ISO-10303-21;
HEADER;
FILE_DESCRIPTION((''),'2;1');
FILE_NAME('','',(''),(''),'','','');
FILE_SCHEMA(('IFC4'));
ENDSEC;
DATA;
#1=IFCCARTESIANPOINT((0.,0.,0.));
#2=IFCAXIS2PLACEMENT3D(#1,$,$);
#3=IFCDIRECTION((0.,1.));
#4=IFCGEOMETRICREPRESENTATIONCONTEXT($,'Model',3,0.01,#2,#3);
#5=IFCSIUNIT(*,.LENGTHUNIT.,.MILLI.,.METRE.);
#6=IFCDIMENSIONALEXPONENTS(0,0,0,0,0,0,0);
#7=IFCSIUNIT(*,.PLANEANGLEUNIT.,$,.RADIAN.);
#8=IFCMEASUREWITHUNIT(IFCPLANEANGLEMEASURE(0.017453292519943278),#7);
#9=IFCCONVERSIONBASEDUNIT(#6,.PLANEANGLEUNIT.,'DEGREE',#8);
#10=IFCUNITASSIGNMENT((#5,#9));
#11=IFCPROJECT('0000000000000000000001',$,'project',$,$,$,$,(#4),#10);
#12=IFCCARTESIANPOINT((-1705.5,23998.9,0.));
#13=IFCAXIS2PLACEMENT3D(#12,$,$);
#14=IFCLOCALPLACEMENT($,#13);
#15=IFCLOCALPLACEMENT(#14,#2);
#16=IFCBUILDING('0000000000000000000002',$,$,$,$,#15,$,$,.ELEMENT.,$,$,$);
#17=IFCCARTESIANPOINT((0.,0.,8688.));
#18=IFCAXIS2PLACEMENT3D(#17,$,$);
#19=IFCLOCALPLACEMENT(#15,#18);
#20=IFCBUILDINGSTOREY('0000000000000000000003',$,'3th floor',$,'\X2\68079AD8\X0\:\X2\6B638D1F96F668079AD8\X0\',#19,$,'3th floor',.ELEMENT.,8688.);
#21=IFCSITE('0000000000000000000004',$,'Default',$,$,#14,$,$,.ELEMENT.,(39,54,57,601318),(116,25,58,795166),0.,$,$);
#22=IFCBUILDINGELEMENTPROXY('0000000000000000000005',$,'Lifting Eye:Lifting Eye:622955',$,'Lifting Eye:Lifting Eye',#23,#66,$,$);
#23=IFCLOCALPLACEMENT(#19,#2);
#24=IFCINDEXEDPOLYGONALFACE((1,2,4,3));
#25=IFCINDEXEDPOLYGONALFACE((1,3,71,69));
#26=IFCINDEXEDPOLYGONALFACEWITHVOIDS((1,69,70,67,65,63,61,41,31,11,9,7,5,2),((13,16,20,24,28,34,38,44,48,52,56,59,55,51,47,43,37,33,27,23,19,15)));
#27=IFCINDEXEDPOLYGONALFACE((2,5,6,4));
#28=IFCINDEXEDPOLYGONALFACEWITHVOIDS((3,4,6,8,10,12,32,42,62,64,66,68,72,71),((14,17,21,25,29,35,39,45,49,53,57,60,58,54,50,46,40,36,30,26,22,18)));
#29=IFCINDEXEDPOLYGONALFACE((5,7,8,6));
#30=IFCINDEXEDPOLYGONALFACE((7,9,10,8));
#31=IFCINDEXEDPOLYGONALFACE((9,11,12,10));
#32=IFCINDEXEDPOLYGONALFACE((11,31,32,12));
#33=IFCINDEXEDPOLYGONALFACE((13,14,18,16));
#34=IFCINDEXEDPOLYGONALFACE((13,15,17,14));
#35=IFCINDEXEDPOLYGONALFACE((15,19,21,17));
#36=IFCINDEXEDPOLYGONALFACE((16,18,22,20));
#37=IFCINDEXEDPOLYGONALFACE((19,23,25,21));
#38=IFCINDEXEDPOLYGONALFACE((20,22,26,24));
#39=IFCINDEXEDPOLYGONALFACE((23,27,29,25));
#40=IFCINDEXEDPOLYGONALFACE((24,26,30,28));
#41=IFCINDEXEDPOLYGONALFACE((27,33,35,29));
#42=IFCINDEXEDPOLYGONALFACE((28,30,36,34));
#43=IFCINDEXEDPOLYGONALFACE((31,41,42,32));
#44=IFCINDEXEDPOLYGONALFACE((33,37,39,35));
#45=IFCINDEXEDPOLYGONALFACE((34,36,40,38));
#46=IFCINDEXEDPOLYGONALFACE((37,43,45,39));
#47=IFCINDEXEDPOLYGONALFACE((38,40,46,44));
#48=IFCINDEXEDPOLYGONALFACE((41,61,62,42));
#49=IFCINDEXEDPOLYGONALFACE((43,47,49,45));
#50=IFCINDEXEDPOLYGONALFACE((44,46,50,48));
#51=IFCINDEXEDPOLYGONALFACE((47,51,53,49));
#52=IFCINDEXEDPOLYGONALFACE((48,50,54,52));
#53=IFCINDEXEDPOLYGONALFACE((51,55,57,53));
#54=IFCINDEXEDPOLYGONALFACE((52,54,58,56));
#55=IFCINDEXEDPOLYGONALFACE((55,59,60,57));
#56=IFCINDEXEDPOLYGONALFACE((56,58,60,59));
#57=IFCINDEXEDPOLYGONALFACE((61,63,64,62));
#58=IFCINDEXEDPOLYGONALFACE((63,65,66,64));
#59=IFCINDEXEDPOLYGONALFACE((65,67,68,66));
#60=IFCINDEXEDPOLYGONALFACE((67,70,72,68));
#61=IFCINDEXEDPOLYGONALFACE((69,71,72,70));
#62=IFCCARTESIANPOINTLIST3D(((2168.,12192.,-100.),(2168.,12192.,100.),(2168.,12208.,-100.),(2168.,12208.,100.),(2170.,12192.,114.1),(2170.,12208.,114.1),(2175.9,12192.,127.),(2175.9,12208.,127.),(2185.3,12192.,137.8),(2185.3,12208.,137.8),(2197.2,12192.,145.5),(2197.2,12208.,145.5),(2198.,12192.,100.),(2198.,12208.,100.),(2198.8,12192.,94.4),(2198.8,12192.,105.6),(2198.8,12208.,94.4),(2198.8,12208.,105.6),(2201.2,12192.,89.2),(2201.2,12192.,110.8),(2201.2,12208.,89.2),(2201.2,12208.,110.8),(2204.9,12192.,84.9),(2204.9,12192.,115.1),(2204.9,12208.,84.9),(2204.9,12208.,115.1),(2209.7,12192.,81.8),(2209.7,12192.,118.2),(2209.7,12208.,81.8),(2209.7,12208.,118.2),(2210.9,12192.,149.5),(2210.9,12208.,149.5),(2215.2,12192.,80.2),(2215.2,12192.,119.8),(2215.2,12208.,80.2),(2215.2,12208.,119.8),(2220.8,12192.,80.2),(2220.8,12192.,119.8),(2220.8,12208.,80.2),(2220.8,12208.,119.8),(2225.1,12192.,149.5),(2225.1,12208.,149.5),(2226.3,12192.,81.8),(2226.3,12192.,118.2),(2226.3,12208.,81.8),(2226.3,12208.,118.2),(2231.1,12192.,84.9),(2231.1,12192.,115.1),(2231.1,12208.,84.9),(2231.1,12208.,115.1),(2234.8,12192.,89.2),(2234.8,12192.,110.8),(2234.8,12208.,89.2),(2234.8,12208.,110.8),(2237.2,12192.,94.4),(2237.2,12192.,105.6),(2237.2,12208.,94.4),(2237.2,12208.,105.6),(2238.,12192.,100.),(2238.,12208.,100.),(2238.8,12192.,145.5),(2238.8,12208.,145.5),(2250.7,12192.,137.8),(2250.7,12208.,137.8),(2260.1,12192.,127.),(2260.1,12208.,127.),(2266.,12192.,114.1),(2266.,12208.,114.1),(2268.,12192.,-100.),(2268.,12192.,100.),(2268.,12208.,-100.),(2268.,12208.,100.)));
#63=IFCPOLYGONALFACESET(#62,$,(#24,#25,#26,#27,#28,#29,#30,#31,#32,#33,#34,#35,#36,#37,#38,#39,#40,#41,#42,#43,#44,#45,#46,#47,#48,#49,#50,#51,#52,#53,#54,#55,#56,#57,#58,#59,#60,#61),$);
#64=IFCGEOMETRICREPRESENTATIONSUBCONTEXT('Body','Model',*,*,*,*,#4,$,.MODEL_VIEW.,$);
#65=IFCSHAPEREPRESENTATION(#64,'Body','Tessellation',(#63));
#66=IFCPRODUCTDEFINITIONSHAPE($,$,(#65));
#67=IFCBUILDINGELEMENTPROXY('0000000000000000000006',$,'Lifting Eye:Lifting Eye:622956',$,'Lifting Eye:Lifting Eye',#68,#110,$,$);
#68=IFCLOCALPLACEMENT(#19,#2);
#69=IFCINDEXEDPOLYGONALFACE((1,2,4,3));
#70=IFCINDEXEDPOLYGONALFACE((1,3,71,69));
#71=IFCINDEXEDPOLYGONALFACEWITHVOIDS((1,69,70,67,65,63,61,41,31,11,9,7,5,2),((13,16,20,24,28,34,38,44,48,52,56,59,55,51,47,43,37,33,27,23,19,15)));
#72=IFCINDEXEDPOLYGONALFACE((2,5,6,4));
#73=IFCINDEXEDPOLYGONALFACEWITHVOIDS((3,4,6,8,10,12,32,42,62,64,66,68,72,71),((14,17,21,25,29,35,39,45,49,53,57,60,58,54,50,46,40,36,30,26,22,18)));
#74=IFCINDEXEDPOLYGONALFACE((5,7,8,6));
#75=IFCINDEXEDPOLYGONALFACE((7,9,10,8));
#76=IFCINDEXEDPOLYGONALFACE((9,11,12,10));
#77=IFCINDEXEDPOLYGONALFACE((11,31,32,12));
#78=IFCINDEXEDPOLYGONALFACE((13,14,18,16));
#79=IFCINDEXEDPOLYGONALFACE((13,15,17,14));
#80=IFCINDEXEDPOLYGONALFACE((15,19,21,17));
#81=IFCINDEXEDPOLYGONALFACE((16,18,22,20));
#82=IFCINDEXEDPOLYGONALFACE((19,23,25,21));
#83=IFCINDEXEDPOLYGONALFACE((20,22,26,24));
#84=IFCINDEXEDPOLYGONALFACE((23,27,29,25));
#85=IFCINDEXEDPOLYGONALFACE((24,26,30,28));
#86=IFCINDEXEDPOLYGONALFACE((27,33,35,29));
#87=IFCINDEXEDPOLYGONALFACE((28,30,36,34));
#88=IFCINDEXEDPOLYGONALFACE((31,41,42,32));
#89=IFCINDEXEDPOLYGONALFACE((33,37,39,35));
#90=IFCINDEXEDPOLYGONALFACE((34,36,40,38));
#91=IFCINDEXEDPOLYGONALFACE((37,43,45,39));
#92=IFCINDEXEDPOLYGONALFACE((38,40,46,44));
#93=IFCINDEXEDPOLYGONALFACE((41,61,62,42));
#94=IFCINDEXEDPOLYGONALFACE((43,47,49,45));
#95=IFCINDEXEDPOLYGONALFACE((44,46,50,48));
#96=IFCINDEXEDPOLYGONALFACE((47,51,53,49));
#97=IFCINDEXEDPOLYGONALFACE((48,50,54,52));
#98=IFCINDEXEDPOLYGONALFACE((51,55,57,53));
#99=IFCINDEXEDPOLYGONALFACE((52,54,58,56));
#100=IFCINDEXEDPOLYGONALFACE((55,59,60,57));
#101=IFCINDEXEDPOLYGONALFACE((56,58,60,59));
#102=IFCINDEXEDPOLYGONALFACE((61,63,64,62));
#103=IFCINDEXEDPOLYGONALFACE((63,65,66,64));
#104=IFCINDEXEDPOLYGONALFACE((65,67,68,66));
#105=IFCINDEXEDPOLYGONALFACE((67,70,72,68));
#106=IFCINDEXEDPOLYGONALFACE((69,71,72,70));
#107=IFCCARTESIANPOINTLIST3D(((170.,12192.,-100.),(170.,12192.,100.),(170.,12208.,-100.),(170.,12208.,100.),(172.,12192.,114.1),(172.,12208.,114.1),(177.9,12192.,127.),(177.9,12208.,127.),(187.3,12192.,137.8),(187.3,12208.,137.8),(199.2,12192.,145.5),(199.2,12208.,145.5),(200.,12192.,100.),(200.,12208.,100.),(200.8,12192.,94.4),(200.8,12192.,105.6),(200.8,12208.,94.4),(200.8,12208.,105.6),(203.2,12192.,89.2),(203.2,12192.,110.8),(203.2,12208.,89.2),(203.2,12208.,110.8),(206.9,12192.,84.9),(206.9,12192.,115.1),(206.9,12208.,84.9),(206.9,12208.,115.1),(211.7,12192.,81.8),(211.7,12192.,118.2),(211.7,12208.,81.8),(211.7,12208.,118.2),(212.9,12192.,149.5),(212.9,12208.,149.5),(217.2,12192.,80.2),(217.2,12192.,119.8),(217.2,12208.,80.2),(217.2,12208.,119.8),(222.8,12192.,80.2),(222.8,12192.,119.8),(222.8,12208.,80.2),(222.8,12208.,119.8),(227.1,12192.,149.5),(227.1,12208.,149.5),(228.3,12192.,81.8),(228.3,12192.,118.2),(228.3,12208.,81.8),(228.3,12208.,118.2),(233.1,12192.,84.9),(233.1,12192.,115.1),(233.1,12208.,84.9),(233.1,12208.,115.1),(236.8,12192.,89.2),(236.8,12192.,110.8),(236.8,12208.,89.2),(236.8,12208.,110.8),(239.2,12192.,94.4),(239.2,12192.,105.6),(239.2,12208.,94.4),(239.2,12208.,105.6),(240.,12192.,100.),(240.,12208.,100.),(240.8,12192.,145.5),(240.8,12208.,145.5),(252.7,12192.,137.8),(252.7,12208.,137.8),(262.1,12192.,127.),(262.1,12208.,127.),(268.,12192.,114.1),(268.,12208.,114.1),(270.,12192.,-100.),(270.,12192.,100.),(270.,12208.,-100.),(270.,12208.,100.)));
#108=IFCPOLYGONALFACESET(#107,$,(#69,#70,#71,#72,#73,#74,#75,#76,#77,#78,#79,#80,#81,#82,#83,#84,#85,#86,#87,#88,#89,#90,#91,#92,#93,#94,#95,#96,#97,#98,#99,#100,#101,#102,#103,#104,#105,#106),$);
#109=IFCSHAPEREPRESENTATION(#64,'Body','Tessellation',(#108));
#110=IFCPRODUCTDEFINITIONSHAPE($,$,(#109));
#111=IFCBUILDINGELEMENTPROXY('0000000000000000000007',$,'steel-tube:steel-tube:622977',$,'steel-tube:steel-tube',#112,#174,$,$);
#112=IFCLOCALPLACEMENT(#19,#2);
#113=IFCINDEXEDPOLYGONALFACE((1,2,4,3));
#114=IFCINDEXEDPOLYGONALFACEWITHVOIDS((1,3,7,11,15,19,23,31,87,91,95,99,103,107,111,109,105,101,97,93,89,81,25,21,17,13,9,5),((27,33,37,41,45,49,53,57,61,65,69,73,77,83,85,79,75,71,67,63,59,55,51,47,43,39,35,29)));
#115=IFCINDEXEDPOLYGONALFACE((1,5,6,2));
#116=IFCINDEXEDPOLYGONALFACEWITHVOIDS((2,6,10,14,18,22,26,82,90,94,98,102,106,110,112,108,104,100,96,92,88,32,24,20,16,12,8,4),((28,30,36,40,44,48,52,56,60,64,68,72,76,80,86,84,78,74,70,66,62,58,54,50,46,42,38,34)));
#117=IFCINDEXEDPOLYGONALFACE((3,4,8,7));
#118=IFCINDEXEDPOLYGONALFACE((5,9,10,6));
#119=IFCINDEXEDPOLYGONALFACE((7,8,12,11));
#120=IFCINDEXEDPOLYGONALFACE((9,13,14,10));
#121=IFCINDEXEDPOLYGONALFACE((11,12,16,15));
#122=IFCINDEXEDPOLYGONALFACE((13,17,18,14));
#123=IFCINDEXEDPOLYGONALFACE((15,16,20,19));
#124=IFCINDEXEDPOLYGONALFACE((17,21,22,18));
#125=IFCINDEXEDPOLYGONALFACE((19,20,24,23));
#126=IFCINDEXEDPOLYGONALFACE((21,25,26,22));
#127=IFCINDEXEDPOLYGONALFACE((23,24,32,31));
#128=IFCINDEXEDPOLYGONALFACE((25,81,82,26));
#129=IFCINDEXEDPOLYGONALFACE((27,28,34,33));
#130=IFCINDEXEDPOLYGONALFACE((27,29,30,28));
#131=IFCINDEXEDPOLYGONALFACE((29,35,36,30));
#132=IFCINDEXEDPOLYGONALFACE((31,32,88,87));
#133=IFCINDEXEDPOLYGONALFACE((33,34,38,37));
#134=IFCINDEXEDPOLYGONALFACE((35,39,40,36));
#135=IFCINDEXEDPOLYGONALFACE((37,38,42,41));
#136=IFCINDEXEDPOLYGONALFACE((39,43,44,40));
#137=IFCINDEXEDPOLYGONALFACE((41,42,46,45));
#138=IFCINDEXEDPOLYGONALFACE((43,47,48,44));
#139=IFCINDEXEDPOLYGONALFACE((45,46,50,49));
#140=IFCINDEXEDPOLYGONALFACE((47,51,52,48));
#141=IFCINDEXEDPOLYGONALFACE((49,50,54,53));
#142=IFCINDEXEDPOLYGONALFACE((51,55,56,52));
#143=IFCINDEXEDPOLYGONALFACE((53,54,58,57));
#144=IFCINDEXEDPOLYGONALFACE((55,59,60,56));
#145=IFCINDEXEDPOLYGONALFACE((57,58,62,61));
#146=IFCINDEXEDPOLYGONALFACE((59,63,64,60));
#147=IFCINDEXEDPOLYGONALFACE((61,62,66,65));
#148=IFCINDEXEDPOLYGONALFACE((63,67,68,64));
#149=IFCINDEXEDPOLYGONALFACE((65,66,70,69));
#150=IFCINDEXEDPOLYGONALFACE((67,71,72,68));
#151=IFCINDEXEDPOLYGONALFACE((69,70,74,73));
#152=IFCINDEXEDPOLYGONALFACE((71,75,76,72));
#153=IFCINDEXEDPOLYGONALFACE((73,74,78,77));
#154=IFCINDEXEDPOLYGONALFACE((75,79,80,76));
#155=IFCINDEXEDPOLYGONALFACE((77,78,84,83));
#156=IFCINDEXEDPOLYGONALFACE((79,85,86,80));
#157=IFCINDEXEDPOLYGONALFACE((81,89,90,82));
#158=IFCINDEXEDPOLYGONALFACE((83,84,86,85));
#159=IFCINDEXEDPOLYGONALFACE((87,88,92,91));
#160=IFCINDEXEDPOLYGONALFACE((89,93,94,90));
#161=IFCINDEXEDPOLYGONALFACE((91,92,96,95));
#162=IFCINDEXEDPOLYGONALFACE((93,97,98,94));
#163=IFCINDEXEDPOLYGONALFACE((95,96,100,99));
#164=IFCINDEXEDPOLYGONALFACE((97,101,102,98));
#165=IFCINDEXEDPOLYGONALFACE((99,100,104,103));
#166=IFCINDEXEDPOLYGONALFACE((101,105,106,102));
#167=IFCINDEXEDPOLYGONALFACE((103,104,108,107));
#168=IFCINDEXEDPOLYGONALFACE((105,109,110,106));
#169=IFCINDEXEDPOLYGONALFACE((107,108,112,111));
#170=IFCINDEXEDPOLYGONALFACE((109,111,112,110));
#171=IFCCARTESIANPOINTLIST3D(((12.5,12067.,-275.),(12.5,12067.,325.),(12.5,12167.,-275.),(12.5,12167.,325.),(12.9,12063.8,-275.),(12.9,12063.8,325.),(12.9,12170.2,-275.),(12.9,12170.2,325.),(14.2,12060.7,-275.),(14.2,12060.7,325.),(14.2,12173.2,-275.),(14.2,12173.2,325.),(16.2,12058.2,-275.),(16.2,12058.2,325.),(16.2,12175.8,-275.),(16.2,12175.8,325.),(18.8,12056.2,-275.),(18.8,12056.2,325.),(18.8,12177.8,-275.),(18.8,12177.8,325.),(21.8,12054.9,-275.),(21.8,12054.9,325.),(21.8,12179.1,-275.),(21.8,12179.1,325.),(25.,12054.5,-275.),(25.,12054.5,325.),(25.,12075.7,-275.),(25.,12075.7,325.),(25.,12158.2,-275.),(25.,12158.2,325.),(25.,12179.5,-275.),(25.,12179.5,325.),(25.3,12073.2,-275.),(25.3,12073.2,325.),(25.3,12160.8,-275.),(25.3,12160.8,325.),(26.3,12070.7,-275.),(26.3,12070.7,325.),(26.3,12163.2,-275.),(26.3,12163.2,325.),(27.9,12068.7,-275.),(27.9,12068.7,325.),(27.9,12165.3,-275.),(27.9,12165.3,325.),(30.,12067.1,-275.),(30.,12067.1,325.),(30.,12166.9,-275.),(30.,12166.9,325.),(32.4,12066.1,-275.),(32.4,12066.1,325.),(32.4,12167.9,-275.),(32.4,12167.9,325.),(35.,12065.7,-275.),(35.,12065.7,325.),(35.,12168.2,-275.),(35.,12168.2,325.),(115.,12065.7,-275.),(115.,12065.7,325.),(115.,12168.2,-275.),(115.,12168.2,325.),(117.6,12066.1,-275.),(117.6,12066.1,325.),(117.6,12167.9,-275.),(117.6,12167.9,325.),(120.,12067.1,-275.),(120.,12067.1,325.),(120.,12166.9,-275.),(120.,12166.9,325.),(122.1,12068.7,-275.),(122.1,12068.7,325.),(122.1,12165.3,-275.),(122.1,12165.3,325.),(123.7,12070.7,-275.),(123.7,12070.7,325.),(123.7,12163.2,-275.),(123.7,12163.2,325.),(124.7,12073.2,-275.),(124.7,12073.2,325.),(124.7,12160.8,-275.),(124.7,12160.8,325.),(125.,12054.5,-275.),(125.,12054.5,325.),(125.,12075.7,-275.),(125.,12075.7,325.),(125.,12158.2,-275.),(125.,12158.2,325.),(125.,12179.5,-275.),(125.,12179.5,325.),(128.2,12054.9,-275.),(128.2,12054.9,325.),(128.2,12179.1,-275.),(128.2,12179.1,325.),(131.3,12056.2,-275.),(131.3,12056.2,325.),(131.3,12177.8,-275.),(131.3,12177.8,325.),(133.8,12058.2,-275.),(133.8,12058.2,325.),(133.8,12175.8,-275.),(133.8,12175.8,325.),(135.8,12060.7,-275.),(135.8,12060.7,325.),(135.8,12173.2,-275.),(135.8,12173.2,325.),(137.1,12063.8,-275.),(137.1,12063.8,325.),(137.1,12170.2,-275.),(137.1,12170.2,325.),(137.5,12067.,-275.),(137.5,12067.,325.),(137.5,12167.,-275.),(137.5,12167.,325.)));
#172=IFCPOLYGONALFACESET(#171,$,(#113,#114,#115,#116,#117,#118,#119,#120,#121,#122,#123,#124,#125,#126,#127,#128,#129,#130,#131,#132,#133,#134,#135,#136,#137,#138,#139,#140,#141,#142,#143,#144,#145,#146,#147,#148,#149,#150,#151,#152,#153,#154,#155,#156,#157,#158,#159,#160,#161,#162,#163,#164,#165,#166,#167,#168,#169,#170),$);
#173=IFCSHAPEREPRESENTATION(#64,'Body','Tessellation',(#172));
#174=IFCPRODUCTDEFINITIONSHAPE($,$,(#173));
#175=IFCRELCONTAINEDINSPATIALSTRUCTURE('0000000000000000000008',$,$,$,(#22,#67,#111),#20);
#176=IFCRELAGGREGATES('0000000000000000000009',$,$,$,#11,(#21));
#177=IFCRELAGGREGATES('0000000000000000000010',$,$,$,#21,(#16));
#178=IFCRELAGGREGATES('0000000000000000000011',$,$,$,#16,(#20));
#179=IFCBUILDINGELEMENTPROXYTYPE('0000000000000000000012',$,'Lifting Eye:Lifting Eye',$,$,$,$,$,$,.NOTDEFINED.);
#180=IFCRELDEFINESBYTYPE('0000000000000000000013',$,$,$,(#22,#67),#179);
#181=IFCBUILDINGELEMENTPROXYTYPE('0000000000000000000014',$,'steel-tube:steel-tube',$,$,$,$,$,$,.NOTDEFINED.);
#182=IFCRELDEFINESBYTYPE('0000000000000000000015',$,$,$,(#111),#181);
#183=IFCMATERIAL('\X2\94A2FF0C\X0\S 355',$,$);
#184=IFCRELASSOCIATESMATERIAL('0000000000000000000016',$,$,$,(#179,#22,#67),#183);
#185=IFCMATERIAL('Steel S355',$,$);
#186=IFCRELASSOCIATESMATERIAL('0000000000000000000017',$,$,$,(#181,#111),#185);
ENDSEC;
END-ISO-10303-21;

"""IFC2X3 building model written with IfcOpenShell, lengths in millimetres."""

from ifc_helpers import new_model, entity, si_unit, converted_unit, direction, frame, frame_2d, origin, place, context, subcontext, project, spatial, polyline, circle_curve, parameter, trimmed, segment, composite_curve, outline, extrude, source, transform, mapped, material, type_object, type_shapes, element, save


model = new_model("IFC2X3")

# Units and contexts
model_context = context("Model", 3, precision=0.01, world=origin(), true_north=direction((0.0, 1.0)))
body_context = subcontext(model_context, "Body", "Model", "MODEL_VIEW")
ifc_project = project(units=[si_unit("LENGTHUNIT", "METRE", prefix="MILLI"), converted_unit("PLANEANGLEUNIT", "DEGREE", entity("IfcPlaneAngleMeasure", 0.017453292519943278), si_unit("PLANEANGLEUNIT", "RADIAN"), dimensions=[0, 0, 0, 0, 0, 0, 0])], contexts=[model_context])

# Site, building, storey
site_placement = place(None, frame((-1705.5, 23998.9, 0.0)))
site = spatial("IfcSite", under=ifc_project, at=site_placement, Name="Default", CompositionType="ELEMENT", RefLatitude=(39, 54, 57, 601318), RefLongitude=(116, 25, 58, 795166), RefElevation=0.0)
building_placement = place(site_placement, origin())
building = spatial("IfcBuilding", under=site, at=building_placement, CompositionType="ELEMENT")
storey_placement = place(building_placement, frame((0.0, 0.0, 8688.0)))
storey = spatial("IfcBuildingStorey", under=building, at=storey_placement, Name="3th floor", ObjectType="标高:正负零标高", LongName="3th floor", CompositionType="ELEMENT", Elevation=8688.0)

# Shared definitions
ifc_material_1 = material(Name="Steel S355")

# Building element proxies
ifc_material_2 = material(Name="钢，S 355")
building_element_proxy_type_1 = type_object("IfcBuildingElementProxyType", Name="Lifting Eye:Lifting Eye", PredefinedType="NOTDEFINED", material=ifc_material_2)
shared_shape_1 = source(origin(), body_context, "Body", "SweptSolid", [
    extrude(outline(composite_curve([segment(polyline([(-100.0, -50.0), (100.0, -50.0)]), True, "CONTINUOUS"), segment(polyline([(100.0, -50.0), (100.0, 50.0)]), True, "CONTINUOUS"), segment(polyline([(100.0, 50.0), (-100.0, 50.0)]), True, "CONTINUOUS"), segment(trimmed(circle_curve(frame_2d((-100.0, 0.0), x_axis=(0.0, -1.0)), 50.0), [parameter(180.0)], [parameter(0.0)], True, "PARAMETER"), True, "CONTINUOUS")], self_intersect=False), holes=[composite_curve([segment(trimmed(circle_curve(frame_2d((-100.0, 0.0), x_axis=(0.0, -1.0)), 20.0), [parameter(180.0)], [parameter(360.0)], True, "PARAMETER"), False, "CONTINUOUS"), segment(trimmed(circle_curve(frame_2d((-100.0, 0.0), x_axis=(0.0, -1.0)), 20.0), [parameter(0.0)], [parameter(180.0)], True, "PARAMETER"), False, "CONTINUOUS")], self_intersect=False)]), frame((0.0, 17.0, -17.0), z_axis=(0.0, 1.0, 0.0), x_axis=(0.0, 0.0, -1.0)), (0.0, 0.0, 1.0), 16.0),
])
type_shapes(building_element_proxy_type_1, [shared_shape_1])
for number, where, name in (
    (1, (2218.0, 12175.0, 17.0), "Lifting Eye:Lifting Eye:622955"),
    (2, (220.0, 12175.0, 17.0), "Lifting Eye:Lifting Eye:622956"),
):
    element("IfcBuildingElementProxy", number, at=place(storey_placement, frame(where)), inside=storey, type_object=building_element_proxy_type_1, material=ifc_material_2, Name=name, ObjectType="Lifting Eye:Lifting Eye", context=body_context, shape_type="MappedRepresentation", body=[
        mapped(shared_shape_1, transform((0.0, 0.0, 0.0), scale=1.0)),
    ])
building_element_proxy_type_2 = type_object("IfcBuildingElementProxyType", Name="steel-tube:steel-tube", PredefinedType="NOTDEFINED", material=ifc_material_1)
shared_shape_2 = source(origin(), body_context, "Body", "SweptSolid", [
    extrude(outline(composite_curve([segment(trimmed(circle_curve(frame_2d((50.0, -50.0), x_axis=(1.0, 0.0)), 12.5), [parameter(270.0)], [parameter(0.0)], True, "PARAMETER"), True, "CONTINUOUS"), segment(polyline([(62.5, -50.0), (62.5, 50.0)]), True, "CONTINUOUS"), segment(trimmed(circle_curve(frame_2d((50.0, 50.0), x_axis=(1.0, 0.0)), 12.5), [parameter(0.0)], [parameter(90.0)], True, "PARAMETER"), True, "CONTINUOUS"), segment(polyline([(50.0, 62.5), (-50.0, 62.5)]), True, "CONTINUOUS"), segment(trimmed(circle_curve(frame_2d((-50.0, 50.0), x_axis=(1.0, 0.0)), 12.5), [parameter(90.0)], [parameter(180.0)], True, "PARAMETER"), True, "CONTINUOUS"), segment(polyline([(-62.5, 50.0), (-62.5, -50.0)]), True, "CONTINUOUS"), segment(trimmed(circle_curve(frame_2d((-50.0, -50.0), x_axis=(1.0, 0.0)), 12.5), [parameter(180.0)], [parameter(270.0)], True, "PARAMETER"), True, "CONTINUOUS"), segment(polyline([(-50.0, -62.5), (50.0, -62.5)]), True, "CONTINUOUS")], self_intersect=False), holes=[composite_curve([segment(trimmed(circle_curve(frame_2d((-41.2, 40.0), x_axis=(1.0, 0.0)), 10.0), [parameter(90.0)], [parameter(180.0)], True, "PARAMETER"), False, "CONTINUOUS"), segment(polyline([(-41.3, 50.0), (41.2, 50.0)]), True, "CONTINUOUS"), segment(trimmed(circle_curve(frame_2d((41.2, 40.0), x_axis=(1.0, 0.0)), 10.0), [parameter(0.0)], [parameter(90.0)], True, "PARAMETER"), False, "CONTINUOUS"), segment(polyline([(51.2, 40.0), (51.2, -40.0)]), True, "CONTINUOUS"), segment(trimmed(circle_curve(frame_2d((41.2, -40.0), x_axis=(1.0, 0.0)), 10.0), [parameter(270.0)], [parameter(360.0)], True, "PARAMETER"), False, "CONTINUOUS"), segment(polyline([(41.2, -50.0), (-41.3, -50.0)]), True, "CONTINUOUS"), segment(trimmed(circle_curve(frame_2d((-41.3, -40.0), x_axis=(1.0, 0.0)), 10.0), [parameter(180.0)], [parameter(270.0)], True, "PARAMETER"), False, "CONTINUOUS"), segment(polyline([(-51.3, -40.0), (-51.3, 40.0)]), True, "CONTINUOUS")], self_intersect=False)]), frame((62.5, 62.5, -175.0)), (0.0, 0.0, 1.0), 600.0),
])
type_shapes(building_element_proxy_type_2, [shared_shape_2])
for number, where, z_axis, x_axis, name in (
    (3, (12.5, 12179.5, -100.0), (0.0, 0.0, 1.0), (0.0, -1.0, 0.0), "steel-tube:steel-tube:622977"),
):
    element("IfcBuildingElementProxy", number, at=place(storey_placement, frame(where, z_axis=z_axis, x_axis=x_axis)), inside=storey, type_object=building_element_proxy_type_2, material=ifc_material_1, Name=name, ObjectType="steel-tube:steel-tube", context=body_context, shape_type="MappedRepresentation", body=[
        mapped(shared_shape_2, transform((0.0, 0.0, 0.0), scale=1.0)),
    ])

save(model, "model.ifc")
